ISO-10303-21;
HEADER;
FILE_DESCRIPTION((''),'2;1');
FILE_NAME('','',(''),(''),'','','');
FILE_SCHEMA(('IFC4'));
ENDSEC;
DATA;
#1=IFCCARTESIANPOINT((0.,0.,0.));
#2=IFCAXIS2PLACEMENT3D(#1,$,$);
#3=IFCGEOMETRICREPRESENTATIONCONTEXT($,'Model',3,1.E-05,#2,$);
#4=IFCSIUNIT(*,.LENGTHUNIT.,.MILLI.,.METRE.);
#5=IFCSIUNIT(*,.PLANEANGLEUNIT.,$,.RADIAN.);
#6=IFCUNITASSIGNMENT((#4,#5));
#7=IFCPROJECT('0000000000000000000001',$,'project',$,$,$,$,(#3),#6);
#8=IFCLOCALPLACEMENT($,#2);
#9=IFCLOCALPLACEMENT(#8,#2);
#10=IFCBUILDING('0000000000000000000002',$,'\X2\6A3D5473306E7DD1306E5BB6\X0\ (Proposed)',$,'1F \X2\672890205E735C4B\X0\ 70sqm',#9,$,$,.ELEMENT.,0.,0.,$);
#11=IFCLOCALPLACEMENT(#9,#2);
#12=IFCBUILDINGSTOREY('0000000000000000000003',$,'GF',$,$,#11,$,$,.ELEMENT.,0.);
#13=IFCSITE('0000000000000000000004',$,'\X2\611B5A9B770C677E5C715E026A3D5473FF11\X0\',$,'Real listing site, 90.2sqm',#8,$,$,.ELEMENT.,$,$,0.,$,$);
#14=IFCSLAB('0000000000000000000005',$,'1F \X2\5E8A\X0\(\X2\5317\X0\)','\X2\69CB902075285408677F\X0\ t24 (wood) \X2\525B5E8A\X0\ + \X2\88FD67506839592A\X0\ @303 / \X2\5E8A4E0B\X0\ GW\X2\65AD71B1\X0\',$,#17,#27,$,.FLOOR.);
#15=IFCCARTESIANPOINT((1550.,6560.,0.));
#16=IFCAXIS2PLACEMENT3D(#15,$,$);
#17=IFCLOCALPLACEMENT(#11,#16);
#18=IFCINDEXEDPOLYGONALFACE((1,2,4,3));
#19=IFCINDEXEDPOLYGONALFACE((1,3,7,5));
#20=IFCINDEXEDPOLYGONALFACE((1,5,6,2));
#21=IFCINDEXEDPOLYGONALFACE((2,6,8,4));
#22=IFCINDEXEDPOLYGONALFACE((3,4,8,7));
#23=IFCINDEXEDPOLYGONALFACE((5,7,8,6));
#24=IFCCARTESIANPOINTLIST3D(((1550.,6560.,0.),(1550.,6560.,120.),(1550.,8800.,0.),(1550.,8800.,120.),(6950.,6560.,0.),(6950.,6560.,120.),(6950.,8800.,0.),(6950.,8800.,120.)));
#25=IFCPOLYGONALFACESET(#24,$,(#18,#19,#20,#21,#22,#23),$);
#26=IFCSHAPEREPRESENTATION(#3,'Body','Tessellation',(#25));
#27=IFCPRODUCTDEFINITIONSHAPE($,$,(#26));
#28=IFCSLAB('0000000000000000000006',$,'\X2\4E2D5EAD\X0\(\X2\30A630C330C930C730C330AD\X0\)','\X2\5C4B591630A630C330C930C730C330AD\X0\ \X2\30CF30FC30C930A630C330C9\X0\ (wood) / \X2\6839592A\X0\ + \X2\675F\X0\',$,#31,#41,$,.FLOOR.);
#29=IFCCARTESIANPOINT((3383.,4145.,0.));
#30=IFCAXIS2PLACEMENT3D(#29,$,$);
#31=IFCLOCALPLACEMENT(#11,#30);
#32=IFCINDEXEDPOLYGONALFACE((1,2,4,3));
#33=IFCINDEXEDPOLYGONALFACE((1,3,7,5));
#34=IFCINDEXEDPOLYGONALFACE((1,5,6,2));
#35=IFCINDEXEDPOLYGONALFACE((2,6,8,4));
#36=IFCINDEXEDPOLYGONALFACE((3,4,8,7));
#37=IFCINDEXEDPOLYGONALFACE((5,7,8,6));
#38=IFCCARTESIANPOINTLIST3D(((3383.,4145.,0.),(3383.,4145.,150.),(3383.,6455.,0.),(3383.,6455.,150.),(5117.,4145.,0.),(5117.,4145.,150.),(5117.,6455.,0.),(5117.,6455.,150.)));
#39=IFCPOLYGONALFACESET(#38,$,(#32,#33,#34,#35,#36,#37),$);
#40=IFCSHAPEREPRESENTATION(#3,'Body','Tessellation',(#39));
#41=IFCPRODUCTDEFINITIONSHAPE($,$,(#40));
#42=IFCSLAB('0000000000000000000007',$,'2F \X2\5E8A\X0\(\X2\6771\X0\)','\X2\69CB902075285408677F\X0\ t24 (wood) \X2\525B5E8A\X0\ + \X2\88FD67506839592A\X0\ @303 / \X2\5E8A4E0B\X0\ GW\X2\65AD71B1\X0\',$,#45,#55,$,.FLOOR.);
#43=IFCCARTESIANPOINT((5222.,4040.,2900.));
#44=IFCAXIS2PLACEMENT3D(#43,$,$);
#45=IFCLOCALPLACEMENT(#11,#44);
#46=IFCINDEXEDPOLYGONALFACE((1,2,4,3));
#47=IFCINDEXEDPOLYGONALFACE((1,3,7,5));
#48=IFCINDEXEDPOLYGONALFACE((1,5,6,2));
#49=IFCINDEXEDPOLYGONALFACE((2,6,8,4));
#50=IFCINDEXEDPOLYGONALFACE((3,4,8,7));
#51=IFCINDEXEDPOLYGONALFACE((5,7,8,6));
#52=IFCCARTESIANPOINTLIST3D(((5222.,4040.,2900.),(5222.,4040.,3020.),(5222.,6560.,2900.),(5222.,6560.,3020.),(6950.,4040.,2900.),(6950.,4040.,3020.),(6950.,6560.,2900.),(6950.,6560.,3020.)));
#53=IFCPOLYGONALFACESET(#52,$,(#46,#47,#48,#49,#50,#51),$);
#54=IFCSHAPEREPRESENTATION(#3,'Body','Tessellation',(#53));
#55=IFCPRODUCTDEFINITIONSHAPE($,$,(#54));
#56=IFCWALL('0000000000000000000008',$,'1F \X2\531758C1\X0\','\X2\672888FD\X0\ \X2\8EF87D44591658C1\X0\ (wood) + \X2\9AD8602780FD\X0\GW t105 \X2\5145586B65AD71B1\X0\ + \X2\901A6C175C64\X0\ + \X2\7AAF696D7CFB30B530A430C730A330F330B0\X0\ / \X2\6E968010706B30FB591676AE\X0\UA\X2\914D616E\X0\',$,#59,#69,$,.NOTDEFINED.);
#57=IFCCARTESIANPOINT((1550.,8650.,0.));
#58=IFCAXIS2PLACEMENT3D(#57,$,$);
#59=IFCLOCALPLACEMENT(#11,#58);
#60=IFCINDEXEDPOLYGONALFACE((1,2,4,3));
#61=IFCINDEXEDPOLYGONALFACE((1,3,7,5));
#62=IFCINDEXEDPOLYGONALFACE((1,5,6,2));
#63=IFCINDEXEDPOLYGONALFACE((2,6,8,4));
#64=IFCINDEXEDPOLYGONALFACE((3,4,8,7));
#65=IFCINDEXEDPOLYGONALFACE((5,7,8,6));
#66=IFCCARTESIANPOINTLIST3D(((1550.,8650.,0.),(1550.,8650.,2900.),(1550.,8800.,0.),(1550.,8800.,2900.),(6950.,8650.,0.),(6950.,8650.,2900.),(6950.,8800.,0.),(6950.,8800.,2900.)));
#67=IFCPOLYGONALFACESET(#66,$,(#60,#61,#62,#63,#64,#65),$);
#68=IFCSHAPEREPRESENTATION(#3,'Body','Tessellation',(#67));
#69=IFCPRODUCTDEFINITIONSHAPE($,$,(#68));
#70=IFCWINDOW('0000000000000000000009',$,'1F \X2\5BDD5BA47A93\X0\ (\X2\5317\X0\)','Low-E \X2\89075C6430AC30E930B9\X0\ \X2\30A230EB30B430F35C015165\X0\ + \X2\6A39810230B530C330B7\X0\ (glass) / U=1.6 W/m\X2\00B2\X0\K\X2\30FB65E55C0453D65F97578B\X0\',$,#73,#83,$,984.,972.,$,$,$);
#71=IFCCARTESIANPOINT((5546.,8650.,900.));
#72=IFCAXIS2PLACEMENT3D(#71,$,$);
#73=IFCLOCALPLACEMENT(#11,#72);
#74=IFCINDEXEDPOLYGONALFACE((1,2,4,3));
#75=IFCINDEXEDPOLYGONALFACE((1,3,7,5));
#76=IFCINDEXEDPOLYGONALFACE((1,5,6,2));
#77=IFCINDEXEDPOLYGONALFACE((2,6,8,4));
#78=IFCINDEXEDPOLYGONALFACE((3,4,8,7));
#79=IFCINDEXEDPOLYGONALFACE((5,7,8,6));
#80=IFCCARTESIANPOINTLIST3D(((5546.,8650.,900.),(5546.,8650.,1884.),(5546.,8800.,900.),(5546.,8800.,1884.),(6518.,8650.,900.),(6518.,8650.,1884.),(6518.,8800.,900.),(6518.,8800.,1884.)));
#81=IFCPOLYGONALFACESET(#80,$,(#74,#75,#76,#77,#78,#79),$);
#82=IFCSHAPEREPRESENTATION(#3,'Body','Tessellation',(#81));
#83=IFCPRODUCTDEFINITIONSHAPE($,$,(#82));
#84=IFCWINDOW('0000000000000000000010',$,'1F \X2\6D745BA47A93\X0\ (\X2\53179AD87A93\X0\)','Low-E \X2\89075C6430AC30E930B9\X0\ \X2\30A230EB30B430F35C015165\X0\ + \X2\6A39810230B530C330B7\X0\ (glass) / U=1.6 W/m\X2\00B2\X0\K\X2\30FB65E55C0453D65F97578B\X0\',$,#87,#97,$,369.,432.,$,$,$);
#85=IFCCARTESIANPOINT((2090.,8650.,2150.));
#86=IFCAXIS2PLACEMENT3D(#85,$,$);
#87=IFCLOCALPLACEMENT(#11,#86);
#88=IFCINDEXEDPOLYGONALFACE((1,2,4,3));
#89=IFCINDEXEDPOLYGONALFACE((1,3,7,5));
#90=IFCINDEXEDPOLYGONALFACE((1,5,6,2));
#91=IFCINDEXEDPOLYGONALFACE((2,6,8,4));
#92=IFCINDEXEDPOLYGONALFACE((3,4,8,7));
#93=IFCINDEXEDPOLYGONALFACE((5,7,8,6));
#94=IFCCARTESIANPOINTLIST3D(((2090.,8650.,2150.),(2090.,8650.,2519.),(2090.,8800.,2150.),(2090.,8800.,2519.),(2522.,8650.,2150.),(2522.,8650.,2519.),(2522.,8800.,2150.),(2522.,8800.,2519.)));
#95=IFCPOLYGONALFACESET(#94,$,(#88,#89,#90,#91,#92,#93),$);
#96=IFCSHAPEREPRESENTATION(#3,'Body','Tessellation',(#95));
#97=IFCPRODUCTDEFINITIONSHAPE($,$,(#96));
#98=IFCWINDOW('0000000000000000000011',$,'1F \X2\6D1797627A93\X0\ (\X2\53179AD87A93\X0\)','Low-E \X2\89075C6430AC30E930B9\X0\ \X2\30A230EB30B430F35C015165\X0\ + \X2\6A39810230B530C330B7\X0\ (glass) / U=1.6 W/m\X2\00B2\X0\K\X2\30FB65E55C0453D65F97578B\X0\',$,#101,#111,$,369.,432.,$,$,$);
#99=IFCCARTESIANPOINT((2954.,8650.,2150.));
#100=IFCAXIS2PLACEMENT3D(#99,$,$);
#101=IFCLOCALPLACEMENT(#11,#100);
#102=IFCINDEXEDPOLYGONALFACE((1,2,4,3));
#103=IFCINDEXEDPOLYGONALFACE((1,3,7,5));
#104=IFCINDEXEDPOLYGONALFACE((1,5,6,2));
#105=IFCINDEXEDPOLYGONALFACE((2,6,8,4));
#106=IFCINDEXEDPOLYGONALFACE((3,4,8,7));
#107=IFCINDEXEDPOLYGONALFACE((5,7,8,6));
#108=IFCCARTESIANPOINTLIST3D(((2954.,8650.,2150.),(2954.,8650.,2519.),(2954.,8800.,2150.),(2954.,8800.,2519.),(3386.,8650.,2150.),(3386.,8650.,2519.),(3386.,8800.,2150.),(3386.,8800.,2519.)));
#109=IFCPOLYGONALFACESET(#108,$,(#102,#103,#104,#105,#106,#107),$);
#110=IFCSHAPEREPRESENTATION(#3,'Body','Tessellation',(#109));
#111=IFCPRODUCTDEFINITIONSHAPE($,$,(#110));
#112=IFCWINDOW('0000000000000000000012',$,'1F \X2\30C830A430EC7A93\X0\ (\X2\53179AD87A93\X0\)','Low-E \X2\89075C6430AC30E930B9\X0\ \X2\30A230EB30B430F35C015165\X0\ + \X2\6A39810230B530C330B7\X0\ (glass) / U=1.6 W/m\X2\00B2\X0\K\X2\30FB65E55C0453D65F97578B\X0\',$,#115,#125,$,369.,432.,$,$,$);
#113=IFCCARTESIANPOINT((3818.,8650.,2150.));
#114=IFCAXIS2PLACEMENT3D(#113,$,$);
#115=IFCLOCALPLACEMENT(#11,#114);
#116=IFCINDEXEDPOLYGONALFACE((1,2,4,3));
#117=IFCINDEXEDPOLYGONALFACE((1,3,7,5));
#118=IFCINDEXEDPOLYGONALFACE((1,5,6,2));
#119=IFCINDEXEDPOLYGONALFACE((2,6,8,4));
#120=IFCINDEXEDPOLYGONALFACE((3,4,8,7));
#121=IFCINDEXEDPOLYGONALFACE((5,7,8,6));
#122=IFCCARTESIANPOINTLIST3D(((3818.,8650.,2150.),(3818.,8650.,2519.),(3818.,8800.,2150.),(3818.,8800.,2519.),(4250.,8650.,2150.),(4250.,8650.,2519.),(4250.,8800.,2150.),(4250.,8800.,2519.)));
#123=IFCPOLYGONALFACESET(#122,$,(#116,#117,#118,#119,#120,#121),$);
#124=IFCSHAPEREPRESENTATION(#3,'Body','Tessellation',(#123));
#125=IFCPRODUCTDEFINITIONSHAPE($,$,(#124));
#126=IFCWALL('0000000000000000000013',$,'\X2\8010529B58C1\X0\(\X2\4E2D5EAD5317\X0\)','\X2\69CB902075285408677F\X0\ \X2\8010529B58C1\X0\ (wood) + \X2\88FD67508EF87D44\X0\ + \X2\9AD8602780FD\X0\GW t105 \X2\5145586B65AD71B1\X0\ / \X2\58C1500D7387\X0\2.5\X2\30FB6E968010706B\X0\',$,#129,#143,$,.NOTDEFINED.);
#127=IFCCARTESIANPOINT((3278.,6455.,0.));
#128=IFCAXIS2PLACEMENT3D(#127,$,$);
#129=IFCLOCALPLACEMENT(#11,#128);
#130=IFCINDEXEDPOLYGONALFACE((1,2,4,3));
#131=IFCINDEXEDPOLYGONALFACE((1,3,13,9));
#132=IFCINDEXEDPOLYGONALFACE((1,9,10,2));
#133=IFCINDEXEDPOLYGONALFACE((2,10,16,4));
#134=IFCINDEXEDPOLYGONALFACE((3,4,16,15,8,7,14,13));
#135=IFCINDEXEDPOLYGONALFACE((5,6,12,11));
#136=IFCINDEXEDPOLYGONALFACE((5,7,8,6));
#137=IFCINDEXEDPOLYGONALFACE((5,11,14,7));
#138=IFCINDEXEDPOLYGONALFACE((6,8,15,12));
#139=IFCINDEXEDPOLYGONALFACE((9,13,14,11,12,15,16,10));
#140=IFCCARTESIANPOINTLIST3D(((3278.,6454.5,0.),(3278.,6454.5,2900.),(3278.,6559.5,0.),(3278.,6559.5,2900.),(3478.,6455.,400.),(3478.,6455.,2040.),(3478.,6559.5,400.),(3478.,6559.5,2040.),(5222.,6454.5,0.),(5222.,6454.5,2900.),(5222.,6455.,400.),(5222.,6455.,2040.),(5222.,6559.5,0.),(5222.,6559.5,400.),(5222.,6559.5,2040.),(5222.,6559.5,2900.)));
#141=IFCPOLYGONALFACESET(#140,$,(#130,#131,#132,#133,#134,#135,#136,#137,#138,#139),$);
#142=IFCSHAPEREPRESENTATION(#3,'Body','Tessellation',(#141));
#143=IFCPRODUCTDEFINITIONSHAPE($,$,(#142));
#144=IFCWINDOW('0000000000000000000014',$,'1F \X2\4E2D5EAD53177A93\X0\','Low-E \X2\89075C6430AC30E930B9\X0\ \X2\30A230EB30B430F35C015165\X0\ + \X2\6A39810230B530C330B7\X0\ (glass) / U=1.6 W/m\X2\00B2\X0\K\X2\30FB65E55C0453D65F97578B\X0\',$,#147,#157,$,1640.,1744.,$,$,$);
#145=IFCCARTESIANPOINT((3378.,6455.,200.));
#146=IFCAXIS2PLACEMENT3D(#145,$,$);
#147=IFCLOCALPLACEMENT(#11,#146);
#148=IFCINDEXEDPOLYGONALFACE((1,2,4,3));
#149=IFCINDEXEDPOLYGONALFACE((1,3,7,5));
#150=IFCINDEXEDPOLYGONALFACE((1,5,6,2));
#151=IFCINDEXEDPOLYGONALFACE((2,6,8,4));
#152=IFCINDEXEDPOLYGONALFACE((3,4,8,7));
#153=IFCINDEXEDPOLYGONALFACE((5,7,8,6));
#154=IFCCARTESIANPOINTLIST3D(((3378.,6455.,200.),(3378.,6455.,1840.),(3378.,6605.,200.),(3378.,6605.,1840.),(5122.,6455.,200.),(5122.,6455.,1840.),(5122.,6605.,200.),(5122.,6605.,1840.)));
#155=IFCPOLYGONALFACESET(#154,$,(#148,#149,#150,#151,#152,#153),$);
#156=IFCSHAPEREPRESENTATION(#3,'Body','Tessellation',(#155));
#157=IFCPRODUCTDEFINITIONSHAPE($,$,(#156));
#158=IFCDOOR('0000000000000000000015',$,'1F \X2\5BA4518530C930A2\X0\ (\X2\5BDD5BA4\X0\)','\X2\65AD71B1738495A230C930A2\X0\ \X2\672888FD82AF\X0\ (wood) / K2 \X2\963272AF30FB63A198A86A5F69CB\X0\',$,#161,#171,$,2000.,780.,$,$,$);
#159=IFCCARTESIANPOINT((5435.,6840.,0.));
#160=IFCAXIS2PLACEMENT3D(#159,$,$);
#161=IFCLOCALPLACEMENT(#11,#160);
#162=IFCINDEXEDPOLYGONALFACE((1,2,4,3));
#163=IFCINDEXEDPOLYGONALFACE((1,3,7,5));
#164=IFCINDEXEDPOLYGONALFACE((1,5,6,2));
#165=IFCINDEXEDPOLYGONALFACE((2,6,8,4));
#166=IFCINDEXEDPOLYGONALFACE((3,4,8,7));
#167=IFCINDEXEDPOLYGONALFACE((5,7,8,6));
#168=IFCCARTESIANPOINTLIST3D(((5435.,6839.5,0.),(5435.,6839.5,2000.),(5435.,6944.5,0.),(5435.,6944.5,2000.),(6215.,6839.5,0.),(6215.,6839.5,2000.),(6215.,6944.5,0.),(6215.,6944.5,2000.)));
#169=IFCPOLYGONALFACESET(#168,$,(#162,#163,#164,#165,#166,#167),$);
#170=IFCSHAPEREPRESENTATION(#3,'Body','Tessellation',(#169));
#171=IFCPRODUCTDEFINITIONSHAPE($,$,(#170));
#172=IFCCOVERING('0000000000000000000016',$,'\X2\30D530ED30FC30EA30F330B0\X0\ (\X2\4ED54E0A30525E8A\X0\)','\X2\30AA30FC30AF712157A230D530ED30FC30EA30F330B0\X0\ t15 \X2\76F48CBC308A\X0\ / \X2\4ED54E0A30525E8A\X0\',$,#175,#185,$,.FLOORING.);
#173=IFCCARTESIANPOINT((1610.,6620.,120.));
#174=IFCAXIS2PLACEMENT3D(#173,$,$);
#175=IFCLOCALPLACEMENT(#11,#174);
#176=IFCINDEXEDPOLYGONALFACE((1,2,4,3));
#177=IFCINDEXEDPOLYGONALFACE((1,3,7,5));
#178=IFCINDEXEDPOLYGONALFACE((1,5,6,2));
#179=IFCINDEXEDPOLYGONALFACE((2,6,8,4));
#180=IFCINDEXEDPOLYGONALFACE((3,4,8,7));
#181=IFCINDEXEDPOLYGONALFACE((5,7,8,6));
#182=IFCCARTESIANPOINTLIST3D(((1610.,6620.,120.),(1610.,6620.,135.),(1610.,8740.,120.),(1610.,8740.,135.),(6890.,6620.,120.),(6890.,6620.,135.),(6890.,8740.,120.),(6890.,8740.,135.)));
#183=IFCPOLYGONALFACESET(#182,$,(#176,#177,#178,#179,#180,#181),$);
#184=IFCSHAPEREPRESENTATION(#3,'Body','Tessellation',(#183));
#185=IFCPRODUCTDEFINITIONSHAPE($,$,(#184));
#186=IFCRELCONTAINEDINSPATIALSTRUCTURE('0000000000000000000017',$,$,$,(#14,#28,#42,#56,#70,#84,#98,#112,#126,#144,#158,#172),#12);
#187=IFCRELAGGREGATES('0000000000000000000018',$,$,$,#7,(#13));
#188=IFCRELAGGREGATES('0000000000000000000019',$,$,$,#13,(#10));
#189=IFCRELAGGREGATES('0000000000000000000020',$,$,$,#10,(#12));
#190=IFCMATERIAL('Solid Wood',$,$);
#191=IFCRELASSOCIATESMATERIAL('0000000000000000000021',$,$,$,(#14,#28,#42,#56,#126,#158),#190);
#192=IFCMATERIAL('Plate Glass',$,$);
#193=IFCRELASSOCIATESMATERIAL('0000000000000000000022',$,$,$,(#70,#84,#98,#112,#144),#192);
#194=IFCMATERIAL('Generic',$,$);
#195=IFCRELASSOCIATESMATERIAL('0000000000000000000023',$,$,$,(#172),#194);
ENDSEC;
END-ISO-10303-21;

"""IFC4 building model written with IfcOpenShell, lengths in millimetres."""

from ifc_helpers import new_model, si_unit, frame, frame_2d, origin, place, context, project, spatial, rectangle, extrude, material, element, fill, save


model = new_model("IFC4")

# Units and contexts
model_context = context("Model", 3, precision=1e-05, world=origin())
ifc_project = project(units=[si_unit("LENGTHUNIT", "METRE", prefix="MILLI"), si_unit("PLANEANGLEUNIT", "RADIAN")], contexts=[model_context])

# Site, building, storey
site_placement = place(None, origin())
site = spatial("IfcSite", under=ifc_project, at=site_placement, Name="愛媛県松山市樽味１", ObjectType="Real listing site, 90.2sqm", CompositionType="ELEMENT", RefElevation=0.0)
building_placement = place(site_placement, origin())
building = spatial("IfcBuilding", under=site, at=building_placement, Name="樽味の緑の家 (Proposed)", ObjectType="1F 木造平屋 70sqm", CompositionType="ELEMENT", ElevationOfRefHeight=0.0, ElevationOfTerrain=0.0)
storey_placement = place(building_placement, origin())
storey = spatial("IfcBuildingStorey", under=building, at=storey_placement, Name="GF", CompositionType="ELEMENT", Elevation=0.0)

# Slabs
ifc_material_1 = material(Name="Solid Wood")
slab_1_placement = place(storey_placement, frame((1550.0, 6560.0, 0.0)))
element("IfcSlab", 1, at=slab_1_placement, inside=storey, material=ifc_material_1, Name="1F 床(北)", Description="構造用合板 t24 (wood) 剛床 + 製材根太 @303 / 床下 GW断熱", PredefinedType="FLOOR", context=model_context, shape_type="SweptSolid", body=[
    extrude(rectangle(XDim=5400.0, YDim=2240.0, at=frame_2d((2700.0, 1120.0))), frame((1550.0, 6560.0, 0.0)), (0.0, 0.0, 1.0), 120.0),
])
slab_2_placement = place(storey_placement, frame((3383.0, 4145.0, 0.0)))
element("IfcSlab", 2, at=slab_2_placement, inside=storey, material=ifc_material_1, Name="中庭(ウッドデッキ)", Description="屋外ウッドデッキ ハードウッド (wood) / 根太 + 束", PredefinedType="FLOOR", context=model_context, shape_type="SweptSolid", body=[
    extrude(rectangle(XDim=1734.0, YDim=2310.0, at=frame_2d((867.0, 1155.0))), frame((3383.0, 4145.0, 0.0)), (0.0, 0.0, 1.0), 150.0),
])
slab_3_placement = place(storey_placement, frame((5222.0, 4040.0, 2900.0)))
element("IfcSlab", 3, at=slab_3_placement, inside=storey, material=ifc_material_1, Name="2F 床(東)", Description="構造用合板 t24 (wood) 剛床 + 製材根太 @303 / 床下 GW断熱", PredefinedType="FLOOR", context=model_context, shape_type="SweptSolid", body=[
    extrude(rectangle(XDim=1728.0, YDim=2520.0, at=frame_2d((864.0, 1260.0))), frame((5222.0, 4040.0, 2900.0)), (0.0, 0.0, 1.0), 120.0),
])

# Wall, openings, windows
wall_1_placement = place(storey_placement, frame((1550.0, 8650.0, 0.0)))
wall_1 = element("IfcWall", 4, at=wall_1_placement, inside=storey, material=ifc_material_1, Name="1F 北壁", Description="木製 軸組外壁 (wood) + 高性能GW t105 充填断熱 + 通気層 + 窯業系サイディング / 準耐火・外皮UA配慮", PredefinedType="NOTDEFINED", context=model_context, shape_type="SweptSolid", body=[
    extrude(rectangle(XDim=5400.0, YDim=150.0, at=frame_2d((2700.0, 75.0))), frame((1550.0, 8650.0, 0.0)), (0.0, 0.0, 1.0), 2900.0),
])
opening_1_placement = place(storey_placement, frame((5546.0, 8650.0, 900.0)))
opening_1 = element("IfcOpeningElement", 5, at=opening_1_placement, cuts=wall_1, PredefinedType="NOTDEFINED", context=model_context, shape_type="SweptSolid", body=[
    extrude(rectangle(XDim=972.0, YDim=150.0, at=frame_2d((486.0, 75.0))), frame((5546.0, 8650.0, 900.0)), (0.0, 0.0, 1.0), 984.0),
])
opening_2_placement = place(storey_placement, frame((2090.0, 8650.0, 2150.0)))
opening_2 = element("IfcOpeningElement", 6, at=opening_2_placement, cuts=wall_1, PredefinedType="NOTDEFINED", context=model_context, shape_type="SweptSolid", body=[
    extrude(rectangle(XDim=432.0, YDim=150.0, at=frame_2d((216.0, 75.0))), frame((2090.0, 8650.0, 2150.0)), (0.0, 0.0, 1.0), 369.0),
])
opening_3_placement = place(storey_placement, frame((2954.0, 8650.0, 2150.0)))
opening_3 = element("IfcOpeningElement", 7, at=opening_3_placement, cuts=wall_1, PredefinedType="NOTDEFINED", context=model_context, shape_type="SweptSolid", body=[
    extrude(rectangle(XDim=432.0, YDim=150.0, at=frame_2d((216.0, 75.0))), frame((2954.0, 8650.0, 2150.0)), (0.0, 0.0, 1.0), 369.0),
])
opening_4_placement = place(storey_placement, frame((3818.0, 8650.0, 2150.0)))
opening_4 = element("IfcOpeningElement", 8, at=opening_4_placement, cuts=wall_1, PredefinedType="NOTDEFINED", context=model_context, shape_type="SweptSolid", body=[
    extrude(rectangle(XDim=432.0, YDim=150.0, at=frame_2d((216.0, 75.0))), frame((3818.0, 8650.0, 2150.0)), (0.0, 0.0, 1.0), 369.0),
])
ifc_material_2 = material(Name="Plate Glass")
window_1_placement = place(storey_placement, frame((5546.0, 8650.0, 900.0)))
window_1 = element("IfcWindow", 9, at=window_1_placement, inside=storey, material=ifc_material_2, Name="1F 寝室窓 (北)", Description="Low-E 複層ガラス アルゴン封入 + 樹脂サッシ (glass) / U=1.6 W/m²K・日射取得型", OverallHeight=984.0, OverallWidth=972.0, context=model_context, shape_type="SweptSolid", body=[
    extrude(rectangle(XDim=972.0, YDim=150.0, at=frame_2d((486.0, 75.0))), frame((5546.0, 8650.0, 900.0)), (0.0, 0.0, 1.0), 984.0),
])
fill(opening_1, window_1)
window_2_placement = place(storey_placement, frame((2090.0, 8650.0, 2150.0)))
window_2 = element("IfcWindow", 10, at=window_2_placement, inside=storey, material=ifc_material_2, Name="1F 浴室窓 (北高窓)", Description="Low-E 複層ガラス アルゴン封入 + 樹脂サッシ (glass) / U=1.6 W/m²K・日射取得型", OverallHeight=369.0, OverallWidth=432.0, context=model_context, shape_type="SweptSolid", body=[
    extrude(rectangle(XDim=432.0, YDim=150.0, at=frame_2d((216.0, 75.0))), frame((2090.0, 8650.0, 2150.0)), (0.0, 0.0, 1.0), 369.0),
])
fill(opening_2, window_2)
window_3_placement = place(storey_placement, frame((2954.0, 8650.0, 2150.0)))
window_3 = element("IfcWindow", 11, at=window_3_placement, inside=storey, material=ifc_material_2, Name="1F 洗面窓 (北高窓)", Description="Low-E 複層ガラス アルゴン封入 + 樹脂サッシ (glass) / U=1.6 W/m²K・日射取得型", OverallHeight=369.0, OverallWidth=432.0, context=model_context, shape_type="SweptSolid", body=[
    extrude(rectangle(XDim=432.0, YDim=150.0, at=frame_2d((216.0, 75.0))), frame((2954.0, 8650.0, 2150.0)), (0.0, 0.0, 1.0), 369.0),
])
fill(opening_3, window_3)
window_4_placement = place(storey_placement, frame((3818.0, 8650.0, 2150.0)))
window_4 = element("IfcWindow", 12, at=window_4_placement, inside=storey, material=ifc_material_2, Name="1F トイレ窓 (北高窓)", Description="Low-E 複層ガラス アルゴン封入 + 樹脂サッシ (glass) / U=1.6 W/m²K・日射取得型", OverallHeight=369.0, OverallWidth=432.0, context=model_context, shape_type="SweptSolid", body=[
    extrude(rectangle(XDim=432.0, YDim=150.0, at=frame_2d((216.0, 75.0))), frame((3818.0, 8650.0, 2150.0)), (0.0, 0.0, 1.0), 369.0),
])
fill(opening_4, window_4)

# Wall, opening, window
wall_2_placement = place(storey_placement, frame((3278.0, 6455.0, 0.0)))
wall_2 = element("IfcWall", 13, at=wall_2_placement, inside=storey, material=ifc_material_1, Name="耐力壁(中庭北)", Description="構造用合板 耐力壁 (wood) + 製材軸組 + 高性能GW t105 充填断熱 / 壁倍率2.5・準耐火", PredefinedType="NOTDEFINED", context=model_context, shape_type="SweptSolid", body=[
    extrude(rectangle(XDim=1944.0, YDim=105.0, at=frame_2d((972.0, 52.0))), frame((3278.0, 6455.0, 0.0)), (0.0, 0.0, 1.0), 2900.0),
])
opening_5_placement = place(storey_placement, frame((3378.0, 6455.0, 200.0)))
opening_5 = element("IfcOpeningElement", 14, at=opening_5_placement, cuts=wall_2, PredefinedType="NOTDEFINED", context=model_context, shape_type="SweptSolid", body=[
    extrude(rectangle(XDim=1744.0, YDim=150.0, at=frame_2d((872.0, 75.0))), frame((3378.0, 6455.0, 200.0)), (0.0, 0.0, 1.0), 1640.0),
])
window_5_placement = place(storey_placement, frame((3378.0, 6455.0, 200.0)))
window_5 = element("IfcWindow", 15, at=window_5_placement, inside=storey, material=ifc_material_2, Name="1F 中庭北窓", Description="Low-E 複層ガラス アルゴン封入 + 樹脂サッシ (glass) / U=1.6 W/m²K・日射取得型", OverallHeight=1640.0, OverallWidth=1744.0, context=model_context, shape_type="SweptSolid", body=[
    extrude(rectangle(XDim=1744.0, YDim=150.0, at=frame_2d((872.0, 75.0))), frame((3378.0, 6455.0, 200.0)), (0.0, 0.0, 1.0), 1640.0),
])
fill(opening_5, window_5)

# Door
door_1_placement = place(storey_placement, frame((5435.0, 6840.0, 0.0)))
element("IfcDoor", 16, at=door_1_placement, inside=storey, material=ifc_material_1, Name="1F 室内ドア (寝室)", Description="断熱玄関ドア 木製芯 (wood) / K2 防犯・採風機構", OverallHeight=2000.0, OverallWidth=780.0, context=model_context, shape_type="SweptSolid", body=[
    extrude(rectangle(XDim=780.0, YDim=105.0, at=frame_2d((390.0, 52.0))), frame((5435.0, 6840.0, 0.0)), (0.0, 0.0, 1.0), 2000.0),
])

# Covering
ifc_material_3 = material(Name="Generic")
covering_1_placement = place(storey_placement, frame((1610.0, 6620.0, 120.0)))
element("IfcCovering", 17, at=covering_1_placement, inside=storey, material=ifc_material_3, Name="フローリング (仕上げ床)", Description="オーク無垢フローリング t15 直貼り / 仕上げ床", PredefinedType="FLOORING", context=model_context, shape_type="SweptSolid", body=[
    extrude(rectangle(XDim=5280.0, YDim=2120.0, at=frame_2d((2640.0, 1060.0))), frame((1610.0, 6620.0, 120.0)), (0.0, 0.0, 1.0), 15.0),
])

save(model, "model.ifc")
